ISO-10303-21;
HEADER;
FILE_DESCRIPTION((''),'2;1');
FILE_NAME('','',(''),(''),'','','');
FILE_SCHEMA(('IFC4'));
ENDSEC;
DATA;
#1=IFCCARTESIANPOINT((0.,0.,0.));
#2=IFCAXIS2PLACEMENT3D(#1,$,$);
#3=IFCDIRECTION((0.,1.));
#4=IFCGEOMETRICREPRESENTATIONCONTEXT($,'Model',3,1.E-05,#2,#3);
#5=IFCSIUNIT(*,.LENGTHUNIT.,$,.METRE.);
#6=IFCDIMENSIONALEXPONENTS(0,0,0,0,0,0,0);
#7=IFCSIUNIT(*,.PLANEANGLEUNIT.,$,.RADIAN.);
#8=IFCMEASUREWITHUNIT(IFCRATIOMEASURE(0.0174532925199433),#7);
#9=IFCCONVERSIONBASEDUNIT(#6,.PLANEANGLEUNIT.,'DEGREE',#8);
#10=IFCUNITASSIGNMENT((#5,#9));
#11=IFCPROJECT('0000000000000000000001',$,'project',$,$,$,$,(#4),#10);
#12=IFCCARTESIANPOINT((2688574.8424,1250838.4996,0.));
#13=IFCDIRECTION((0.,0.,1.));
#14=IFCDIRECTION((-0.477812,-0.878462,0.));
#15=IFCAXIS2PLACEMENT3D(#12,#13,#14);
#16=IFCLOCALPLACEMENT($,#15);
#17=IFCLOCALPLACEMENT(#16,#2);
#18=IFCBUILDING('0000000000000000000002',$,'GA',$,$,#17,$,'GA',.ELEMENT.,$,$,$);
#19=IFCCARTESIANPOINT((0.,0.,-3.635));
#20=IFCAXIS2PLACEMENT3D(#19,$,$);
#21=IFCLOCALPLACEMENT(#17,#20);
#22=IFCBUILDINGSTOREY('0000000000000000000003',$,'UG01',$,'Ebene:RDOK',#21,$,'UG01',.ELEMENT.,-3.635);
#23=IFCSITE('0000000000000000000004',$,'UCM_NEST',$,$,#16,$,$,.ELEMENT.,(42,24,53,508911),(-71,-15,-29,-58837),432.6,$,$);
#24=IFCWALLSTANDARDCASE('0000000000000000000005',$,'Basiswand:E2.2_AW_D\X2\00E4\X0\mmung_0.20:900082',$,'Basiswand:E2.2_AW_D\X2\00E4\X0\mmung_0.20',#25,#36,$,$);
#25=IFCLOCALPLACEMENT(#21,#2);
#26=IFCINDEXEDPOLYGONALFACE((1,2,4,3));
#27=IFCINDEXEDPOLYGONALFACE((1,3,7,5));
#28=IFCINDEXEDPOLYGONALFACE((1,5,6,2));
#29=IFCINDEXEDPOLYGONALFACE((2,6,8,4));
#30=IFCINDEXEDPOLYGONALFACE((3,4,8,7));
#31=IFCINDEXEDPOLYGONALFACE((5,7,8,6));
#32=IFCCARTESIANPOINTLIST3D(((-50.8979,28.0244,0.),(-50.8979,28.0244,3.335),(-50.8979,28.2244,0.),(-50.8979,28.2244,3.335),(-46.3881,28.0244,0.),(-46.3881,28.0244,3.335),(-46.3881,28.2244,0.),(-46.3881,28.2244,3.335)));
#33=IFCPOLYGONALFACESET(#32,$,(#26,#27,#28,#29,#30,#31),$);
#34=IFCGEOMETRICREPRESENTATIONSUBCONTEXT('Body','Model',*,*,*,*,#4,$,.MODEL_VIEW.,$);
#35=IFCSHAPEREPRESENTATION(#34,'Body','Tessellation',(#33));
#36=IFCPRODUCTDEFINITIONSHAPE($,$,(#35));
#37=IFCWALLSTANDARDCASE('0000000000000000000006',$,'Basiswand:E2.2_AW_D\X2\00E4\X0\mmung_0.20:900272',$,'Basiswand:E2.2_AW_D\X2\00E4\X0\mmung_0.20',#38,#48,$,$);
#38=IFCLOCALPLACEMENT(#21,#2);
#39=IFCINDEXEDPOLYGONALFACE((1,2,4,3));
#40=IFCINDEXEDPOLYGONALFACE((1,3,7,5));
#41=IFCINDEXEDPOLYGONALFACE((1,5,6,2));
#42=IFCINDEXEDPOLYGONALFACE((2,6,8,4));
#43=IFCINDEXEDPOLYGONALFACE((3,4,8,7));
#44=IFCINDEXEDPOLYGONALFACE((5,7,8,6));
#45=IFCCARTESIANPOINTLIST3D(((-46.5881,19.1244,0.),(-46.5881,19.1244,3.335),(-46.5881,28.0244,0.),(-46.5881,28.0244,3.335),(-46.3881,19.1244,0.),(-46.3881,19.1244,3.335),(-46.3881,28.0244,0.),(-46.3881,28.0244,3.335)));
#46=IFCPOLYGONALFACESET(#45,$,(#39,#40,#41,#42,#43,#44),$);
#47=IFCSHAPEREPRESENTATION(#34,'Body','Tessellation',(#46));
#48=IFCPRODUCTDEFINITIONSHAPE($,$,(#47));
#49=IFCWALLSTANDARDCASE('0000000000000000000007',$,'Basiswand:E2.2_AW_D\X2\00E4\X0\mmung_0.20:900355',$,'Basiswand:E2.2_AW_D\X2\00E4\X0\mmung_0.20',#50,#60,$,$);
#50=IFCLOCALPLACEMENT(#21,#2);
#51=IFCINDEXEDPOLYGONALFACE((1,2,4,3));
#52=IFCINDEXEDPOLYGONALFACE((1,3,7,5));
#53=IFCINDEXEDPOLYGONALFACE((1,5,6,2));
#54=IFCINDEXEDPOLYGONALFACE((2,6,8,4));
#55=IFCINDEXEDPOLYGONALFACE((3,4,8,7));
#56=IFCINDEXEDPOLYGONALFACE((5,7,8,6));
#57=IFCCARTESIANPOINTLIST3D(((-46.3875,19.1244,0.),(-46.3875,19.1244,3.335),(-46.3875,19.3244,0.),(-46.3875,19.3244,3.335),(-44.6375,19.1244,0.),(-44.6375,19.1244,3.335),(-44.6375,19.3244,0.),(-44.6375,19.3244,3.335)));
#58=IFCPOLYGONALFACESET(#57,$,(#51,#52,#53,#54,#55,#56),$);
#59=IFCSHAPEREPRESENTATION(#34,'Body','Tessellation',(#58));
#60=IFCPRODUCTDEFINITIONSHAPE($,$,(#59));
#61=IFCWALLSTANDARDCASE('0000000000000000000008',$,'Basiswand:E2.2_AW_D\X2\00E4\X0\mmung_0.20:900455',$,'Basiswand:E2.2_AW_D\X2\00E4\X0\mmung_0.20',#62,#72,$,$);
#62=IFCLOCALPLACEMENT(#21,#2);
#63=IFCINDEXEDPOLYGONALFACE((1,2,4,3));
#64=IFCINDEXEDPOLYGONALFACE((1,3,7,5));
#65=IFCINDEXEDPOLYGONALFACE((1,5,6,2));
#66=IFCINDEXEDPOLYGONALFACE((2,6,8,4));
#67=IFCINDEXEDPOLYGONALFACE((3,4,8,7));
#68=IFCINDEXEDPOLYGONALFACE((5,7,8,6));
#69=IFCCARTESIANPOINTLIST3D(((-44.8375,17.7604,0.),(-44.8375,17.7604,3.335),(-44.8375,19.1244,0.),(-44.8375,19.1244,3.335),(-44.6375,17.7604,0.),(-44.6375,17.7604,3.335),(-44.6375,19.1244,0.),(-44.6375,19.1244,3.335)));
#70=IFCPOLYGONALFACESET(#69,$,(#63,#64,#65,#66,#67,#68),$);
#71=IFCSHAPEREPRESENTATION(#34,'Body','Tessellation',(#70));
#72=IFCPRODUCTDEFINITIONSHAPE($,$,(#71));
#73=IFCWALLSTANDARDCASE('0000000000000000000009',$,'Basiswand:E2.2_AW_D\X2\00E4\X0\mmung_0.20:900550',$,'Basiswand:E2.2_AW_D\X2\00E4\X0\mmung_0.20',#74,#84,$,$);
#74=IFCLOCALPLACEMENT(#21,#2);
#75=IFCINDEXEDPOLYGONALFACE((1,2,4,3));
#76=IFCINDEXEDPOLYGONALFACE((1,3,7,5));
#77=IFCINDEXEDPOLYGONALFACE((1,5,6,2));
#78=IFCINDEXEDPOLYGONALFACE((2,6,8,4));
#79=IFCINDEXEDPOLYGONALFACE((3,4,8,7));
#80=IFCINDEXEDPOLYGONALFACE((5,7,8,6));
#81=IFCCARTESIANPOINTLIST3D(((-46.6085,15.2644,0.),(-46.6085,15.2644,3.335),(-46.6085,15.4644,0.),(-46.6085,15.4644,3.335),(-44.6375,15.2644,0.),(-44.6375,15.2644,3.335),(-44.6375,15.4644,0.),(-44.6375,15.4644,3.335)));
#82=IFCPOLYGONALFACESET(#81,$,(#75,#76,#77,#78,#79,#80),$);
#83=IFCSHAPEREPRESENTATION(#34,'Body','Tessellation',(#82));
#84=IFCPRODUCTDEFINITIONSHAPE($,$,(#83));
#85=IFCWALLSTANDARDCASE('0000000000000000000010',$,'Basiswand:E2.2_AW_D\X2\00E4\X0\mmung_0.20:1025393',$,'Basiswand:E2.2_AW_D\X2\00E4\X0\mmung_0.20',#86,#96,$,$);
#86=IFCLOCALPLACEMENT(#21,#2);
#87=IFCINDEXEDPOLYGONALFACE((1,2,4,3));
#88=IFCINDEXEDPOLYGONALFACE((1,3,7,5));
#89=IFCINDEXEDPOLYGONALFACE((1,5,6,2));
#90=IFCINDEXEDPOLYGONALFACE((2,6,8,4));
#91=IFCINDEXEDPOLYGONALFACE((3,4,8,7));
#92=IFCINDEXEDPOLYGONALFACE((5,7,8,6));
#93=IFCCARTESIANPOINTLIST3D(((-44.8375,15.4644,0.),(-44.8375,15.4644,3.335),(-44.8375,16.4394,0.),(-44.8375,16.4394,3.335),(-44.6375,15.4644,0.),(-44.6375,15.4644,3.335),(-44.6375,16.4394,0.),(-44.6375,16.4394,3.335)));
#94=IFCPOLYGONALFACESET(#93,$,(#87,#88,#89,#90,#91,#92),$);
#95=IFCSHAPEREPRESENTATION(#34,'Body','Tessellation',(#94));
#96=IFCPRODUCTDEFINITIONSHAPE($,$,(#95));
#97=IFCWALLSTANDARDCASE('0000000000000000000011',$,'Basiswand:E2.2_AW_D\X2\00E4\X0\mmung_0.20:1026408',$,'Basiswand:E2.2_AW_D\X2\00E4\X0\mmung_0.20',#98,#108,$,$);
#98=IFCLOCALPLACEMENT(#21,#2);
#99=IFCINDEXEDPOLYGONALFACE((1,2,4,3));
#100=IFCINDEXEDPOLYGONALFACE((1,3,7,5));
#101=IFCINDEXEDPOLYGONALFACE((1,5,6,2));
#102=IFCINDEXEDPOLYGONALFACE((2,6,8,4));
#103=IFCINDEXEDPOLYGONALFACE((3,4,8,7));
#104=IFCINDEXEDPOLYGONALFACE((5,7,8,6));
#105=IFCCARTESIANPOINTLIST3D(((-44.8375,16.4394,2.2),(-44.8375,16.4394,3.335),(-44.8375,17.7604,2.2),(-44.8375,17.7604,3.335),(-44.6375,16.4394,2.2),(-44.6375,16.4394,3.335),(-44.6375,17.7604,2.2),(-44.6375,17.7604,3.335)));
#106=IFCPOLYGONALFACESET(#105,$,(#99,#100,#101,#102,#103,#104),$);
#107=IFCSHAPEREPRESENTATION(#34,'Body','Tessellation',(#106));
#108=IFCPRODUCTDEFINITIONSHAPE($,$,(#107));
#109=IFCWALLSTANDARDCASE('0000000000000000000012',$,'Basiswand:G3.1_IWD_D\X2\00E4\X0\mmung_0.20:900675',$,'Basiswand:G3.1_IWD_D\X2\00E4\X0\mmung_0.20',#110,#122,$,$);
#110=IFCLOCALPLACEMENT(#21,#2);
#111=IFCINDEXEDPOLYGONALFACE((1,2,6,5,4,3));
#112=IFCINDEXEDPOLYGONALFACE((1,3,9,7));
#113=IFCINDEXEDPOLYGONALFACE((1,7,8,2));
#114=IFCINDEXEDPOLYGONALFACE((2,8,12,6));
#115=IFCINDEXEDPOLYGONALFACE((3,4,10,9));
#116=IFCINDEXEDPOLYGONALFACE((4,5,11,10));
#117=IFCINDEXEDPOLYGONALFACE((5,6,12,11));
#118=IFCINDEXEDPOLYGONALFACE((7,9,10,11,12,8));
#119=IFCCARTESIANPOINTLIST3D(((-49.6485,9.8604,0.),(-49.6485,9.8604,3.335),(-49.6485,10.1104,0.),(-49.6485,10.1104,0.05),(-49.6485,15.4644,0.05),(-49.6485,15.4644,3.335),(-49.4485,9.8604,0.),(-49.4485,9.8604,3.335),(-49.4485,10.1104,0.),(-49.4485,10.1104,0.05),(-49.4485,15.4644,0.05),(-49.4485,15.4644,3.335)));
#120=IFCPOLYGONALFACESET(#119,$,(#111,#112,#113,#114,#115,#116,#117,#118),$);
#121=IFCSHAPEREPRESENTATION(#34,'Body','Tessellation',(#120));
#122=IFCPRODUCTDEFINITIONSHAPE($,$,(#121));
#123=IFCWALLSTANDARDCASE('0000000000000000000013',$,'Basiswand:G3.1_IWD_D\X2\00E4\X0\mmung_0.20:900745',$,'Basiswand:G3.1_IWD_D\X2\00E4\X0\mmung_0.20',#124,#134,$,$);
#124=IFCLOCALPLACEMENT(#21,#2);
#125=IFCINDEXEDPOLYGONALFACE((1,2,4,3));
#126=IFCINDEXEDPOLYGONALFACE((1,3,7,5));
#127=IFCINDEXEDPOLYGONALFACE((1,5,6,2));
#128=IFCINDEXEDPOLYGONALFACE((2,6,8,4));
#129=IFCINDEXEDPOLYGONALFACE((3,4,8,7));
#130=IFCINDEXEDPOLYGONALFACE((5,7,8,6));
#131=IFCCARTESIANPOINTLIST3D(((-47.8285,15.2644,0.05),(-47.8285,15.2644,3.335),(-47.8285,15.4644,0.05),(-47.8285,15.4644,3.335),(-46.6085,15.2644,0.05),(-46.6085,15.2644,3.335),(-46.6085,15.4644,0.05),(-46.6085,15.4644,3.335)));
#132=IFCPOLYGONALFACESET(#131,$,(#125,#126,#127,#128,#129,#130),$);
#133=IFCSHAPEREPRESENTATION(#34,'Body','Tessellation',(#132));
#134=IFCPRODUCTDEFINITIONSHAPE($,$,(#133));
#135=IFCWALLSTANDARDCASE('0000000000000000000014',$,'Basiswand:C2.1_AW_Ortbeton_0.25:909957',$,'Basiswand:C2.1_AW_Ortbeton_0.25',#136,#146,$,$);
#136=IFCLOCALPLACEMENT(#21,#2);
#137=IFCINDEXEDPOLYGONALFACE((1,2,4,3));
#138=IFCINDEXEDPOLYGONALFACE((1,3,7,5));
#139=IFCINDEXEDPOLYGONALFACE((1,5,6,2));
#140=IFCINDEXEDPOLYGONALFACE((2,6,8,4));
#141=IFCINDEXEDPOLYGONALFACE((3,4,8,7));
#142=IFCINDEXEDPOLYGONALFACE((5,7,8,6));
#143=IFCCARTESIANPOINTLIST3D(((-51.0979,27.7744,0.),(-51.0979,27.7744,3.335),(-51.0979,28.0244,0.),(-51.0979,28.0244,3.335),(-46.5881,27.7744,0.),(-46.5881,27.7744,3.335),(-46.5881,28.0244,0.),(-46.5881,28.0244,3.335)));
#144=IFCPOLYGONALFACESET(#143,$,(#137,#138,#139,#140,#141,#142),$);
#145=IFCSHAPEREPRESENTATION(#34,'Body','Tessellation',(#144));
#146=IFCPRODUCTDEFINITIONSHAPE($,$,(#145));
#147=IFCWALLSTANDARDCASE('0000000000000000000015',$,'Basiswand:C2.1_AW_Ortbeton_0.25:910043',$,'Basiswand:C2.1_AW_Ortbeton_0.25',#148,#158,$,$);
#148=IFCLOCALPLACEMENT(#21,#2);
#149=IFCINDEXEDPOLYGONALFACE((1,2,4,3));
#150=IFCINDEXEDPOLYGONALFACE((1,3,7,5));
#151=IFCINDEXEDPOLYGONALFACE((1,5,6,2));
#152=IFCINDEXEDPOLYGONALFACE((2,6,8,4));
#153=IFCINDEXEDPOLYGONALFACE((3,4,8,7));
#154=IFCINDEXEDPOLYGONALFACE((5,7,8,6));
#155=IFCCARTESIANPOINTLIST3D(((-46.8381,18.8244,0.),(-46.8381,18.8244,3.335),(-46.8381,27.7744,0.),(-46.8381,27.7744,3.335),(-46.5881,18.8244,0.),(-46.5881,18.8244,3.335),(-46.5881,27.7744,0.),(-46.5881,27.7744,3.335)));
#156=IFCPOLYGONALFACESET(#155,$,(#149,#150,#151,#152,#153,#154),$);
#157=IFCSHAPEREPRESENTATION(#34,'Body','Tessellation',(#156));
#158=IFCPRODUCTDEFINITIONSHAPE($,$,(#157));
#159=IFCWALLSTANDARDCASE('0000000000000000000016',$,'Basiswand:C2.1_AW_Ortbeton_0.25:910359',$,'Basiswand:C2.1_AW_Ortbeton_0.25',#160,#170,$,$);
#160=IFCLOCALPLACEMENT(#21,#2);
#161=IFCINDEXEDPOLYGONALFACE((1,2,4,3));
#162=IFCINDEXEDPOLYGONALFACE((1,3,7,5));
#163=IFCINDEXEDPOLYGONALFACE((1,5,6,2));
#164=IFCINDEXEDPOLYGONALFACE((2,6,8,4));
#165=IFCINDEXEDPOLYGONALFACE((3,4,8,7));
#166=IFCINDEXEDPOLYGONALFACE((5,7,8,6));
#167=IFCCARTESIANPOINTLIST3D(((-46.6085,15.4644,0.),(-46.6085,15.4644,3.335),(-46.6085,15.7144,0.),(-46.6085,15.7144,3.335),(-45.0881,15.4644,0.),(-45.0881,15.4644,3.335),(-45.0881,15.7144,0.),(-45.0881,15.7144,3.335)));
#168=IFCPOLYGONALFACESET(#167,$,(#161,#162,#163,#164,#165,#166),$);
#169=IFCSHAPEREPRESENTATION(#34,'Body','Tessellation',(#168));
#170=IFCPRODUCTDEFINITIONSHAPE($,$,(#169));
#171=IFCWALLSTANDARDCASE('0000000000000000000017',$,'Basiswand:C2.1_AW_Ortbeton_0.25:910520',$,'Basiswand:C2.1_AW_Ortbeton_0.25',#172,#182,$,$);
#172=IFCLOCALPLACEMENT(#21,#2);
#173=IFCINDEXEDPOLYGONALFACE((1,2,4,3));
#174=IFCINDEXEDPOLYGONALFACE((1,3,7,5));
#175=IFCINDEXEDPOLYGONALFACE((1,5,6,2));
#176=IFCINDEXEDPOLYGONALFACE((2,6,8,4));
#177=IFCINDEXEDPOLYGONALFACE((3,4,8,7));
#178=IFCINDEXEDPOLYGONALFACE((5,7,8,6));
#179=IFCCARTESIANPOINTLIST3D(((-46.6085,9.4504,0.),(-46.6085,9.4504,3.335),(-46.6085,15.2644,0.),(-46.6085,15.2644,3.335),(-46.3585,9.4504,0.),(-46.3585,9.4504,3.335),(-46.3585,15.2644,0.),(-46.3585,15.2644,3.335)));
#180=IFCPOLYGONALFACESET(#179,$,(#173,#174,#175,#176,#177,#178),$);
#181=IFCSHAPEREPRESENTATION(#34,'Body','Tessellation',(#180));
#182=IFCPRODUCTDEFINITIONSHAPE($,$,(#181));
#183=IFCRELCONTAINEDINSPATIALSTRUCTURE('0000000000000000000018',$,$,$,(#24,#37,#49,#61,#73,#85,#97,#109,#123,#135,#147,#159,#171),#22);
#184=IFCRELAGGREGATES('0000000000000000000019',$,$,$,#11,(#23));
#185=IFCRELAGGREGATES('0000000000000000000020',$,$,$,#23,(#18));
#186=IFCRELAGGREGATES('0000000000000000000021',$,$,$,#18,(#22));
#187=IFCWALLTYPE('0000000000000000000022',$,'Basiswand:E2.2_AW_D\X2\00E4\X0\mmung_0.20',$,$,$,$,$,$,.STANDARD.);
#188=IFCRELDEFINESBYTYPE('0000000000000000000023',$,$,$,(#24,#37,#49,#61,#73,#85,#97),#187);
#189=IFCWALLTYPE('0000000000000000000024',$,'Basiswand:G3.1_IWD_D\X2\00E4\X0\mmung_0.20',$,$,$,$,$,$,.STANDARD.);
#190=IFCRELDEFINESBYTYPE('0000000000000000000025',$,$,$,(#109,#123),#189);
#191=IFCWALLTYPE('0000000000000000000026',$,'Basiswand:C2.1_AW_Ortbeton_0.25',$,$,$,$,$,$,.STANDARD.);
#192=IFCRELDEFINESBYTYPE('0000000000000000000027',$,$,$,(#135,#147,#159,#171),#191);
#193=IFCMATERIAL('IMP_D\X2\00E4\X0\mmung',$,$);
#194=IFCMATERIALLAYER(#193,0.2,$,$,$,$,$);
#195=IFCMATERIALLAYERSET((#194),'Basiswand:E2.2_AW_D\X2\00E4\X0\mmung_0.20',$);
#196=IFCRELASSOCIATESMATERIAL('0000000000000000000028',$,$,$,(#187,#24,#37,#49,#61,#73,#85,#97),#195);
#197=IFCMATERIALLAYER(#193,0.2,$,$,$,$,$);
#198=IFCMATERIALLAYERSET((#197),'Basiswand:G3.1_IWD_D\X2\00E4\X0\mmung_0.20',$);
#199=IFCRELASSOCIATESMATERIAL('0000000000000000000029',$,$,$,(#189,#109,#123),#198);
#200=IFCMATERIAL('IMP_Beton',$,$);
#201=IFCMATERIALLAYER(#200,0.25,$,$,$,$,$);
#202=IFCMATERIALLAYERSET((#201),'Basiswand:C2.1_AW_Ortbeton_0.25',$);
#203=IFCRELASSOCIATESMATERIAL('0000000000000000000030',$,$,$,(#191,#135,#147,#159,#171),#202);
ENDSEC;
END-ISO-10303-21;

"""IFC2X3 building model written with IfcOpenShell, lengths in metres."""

from ifc_helpers import new_model, entity, si_unit, converted_unit, direction, frame, frame_2d, origin, place, context, subcontext, project, spatial, polyline, rectangle, extrude, clip, bounded_halfspace, material, layer, layer_set, layer_usage, type_object, element, save


model = new_model("IFC2X3")

# Units and contexts
model_context = context("Model", 3, precision=1e-05, world=origin(), true_north=direction((0.0, 1.0)))
body_context = subcontext(model_context, "Body", "Model", "MODEL_VIEW")
ifc_project = project(units=[si_unit("LENGTHUNIT", "METRE"), converted_unit("PLANEANGLEUNIT", "DEGREE", entity("IfcRatioMeasure", 0.0174532925199433), si_unit("PLANEANGLEUNIT", "RADIAN"), dimensions=[0, 0, 0, 0, 0, 0, 0])], contexts=[model_context])

# Site, building, storey
site_placement = place(None, frame((2688574.8424, 1250838.4996, 0.0), z_axis=(0.0, 0.0, 1.0), x_axis=(-0.477812, -0.878462, 0.0)))
site = spatial("IfcSite", under=ifc_project, at=site_placement, Name="UCM_NEST", CompositionType="ELEMENT", RefLatitude=(42, 24, 53, 508911), RefLongitude=(-71, -15, -29, -58837), RefElevation=432.6)
building_placement = place(site_placement, origin())
building = spatial("IfcBuilding", under=site, at=building_placement, Name="GA", LongName="GA", CompositionType="ELEMENT")
storey_placement = place(building_placement, frame((0.0, 0.0, -3.635)))
storey = spatial("IfcBuildingStorey", under=building, at=storey_placement, Name="UG01", ObjectType="Ebene:RDOK", LongName="UG01", CompositionType="ELEMENT", Elevation=-3.635)

# Shared definitions
ifc_material_1 = material(Name="IMP_Beton")

# Walls
ifc_material_2 = material(Name="IMP_Dämmung")
ifc_layer_1 = layer(ifc_material_2, 0.2)
ifc_layer_set_1 = layer_set([ifc_layer_1], Name="Basiswand:E2.2_AW_Dämmung_0.20")
ifc_layer_usage_1 = layer_usage(ifc_layer_set_1, "AXIS2", "NEGATIVE", 0.1)
wall_type_1 = type_object("IfcWallType", Name="Basiswand:E2.2_AW_Dämmung_0.20", PredefinedType="STANDARD", material=ifc_layer_set_1)
wall_1_placement = place(storey_placement, frame((-50.8979, 28.1244, 0.0)))
element("IfcWallStandardCase", 1, at=wall_1_placement, inside=storey, type_object=wall_type_1, material=ifc_layer_usage_1, Name="Basiswand:E2.2_AW_Dämmung_0.20:900082", ObjectType="Basiswand:E2.2_AW_Dämmung_0.20", context=body_context, shape_type="SweptSolid", body=[
    extrude(rectangle(XDim=4.5099, YDim=0.2, at=frame_2d((2.2549, 0.0), x_axis=(-1.0, 0.0))), origin(), (0.0, 0.0, 1.0), 3.335),
])
ifc_layer_usage_2 = layer_usage(ifc_layer_set_1, "AXIS2", "NEGATIVE", 0.1)
wall_2_placement = place(storey_placement, frame((-46.4881, 28.0244, 0.0), z_axis=(0.0, 0.0, 1.0), x_axis=(0.0, -1.0, 0.0)))
element("IfcWallStandardCase", 2, at=wall_2_placement, inside=storey, type_object=wall_type_1, material=ifc_layer_usage_2, Name="Basiswand:E2.2_AW_Dämmung_0.20:900272", ObjectType="Basiswand:E2.2_AW_Dämmung_0.20", context=body_context, shape_type="SweptSolid", body=[
    extrude(rectangle(XDim=8.9, YDim=0.2, at=frame_2d((4.45, 0.0), x_axis=(-1.0, 0.0))), origin(), (0.0, 0.0, 1.0), 3.335),
])
ifc_layer_usage_3 = layer_usage(ifc_layer_set_1, "AXIS2", "NEGATIVE", 0.1)
wall_3_placement = place(storey_placement, frame((-46.3875, 19.2244, 0.0)))
element("IfcWallStandardCase", 3, at=wall_3_placement, inside=storey, type_object=wall_type_1, material=ifc_layer_usage_3, Name="Basiswand:E2.2_AW_Dämmung_0.20:900355", ObjectType="Basiswand:E2.2_AW_Dämmung_0.20", context=body_context, shape_type="SweptSolid", body=[
    extrude(rectangle(XDim=1.75, YDim=0.2, at=frame_2d((0.875, 0.0), x_axis=(-1.0, 0.0))), origin(), (0.0, 0.0, 1.0), 3.335),
])
ifc_layer_usage_4 = layer_usage(ifc_layer_set_1, "AXIS2", "NEGATIVE", 0.1)
wall_4_placement = place(storey_placement, frame((-44.7375, 19.1244, 0.0), z_axis=(0.0, 0.0, 1.0), x_axis=(0.0, -1.0, 0.0)))
element("IfcWallStandardCase", 4, at=wall_4_placement, inside=storey, type_object=wall_type_1, material=ifc_layer_usage_4, Name="Basiswand:E2.2_AW_Dämmung_0.20:900455", ObjectType="Basiswand:E2.2_AW_Dämmung_0.20", context=body_context, shape_type="SweptSolid", body=[
    extrude(rectangle(XDim=1.364, YDim=0.2, at=frame_2d((0.682, 0.0), x_axis=(-1.0, 0.0))), origin(), (0.0, 0.0, 1.0), 3.335),
])
ifc_layer_usage_5 = layer_usage(ifc_layer_set_1, "AXIS2", "NEGATIVE", 0.1)
wall_5_placement = place(storey_placement, frame((-44.6375, 15.3644, 0.0), z_axis=(0.0, 0.0, 1.0), x_axis=(-1.0, 0.0, 0.0)))
element("IfcWallStandardCase", 5, at=wall_5_placement, inside=storey, type_object=wall_type_1, material=ifc_layer_usage_5, Name="Basiswand:E2.2_AW_Dämmung_0.20:900550", ObjectType="Basiswand:E2.2_AW_Dämmung_0.20", context=body_context, shape_type="SweptSolid", body=[
    extrude(rectangle(XDim=1.971, YDim=0.2, at=frame_2d((0.9855, 0.0), x_axis=(-1.0, 0.0))), origin(), (0.0, 0.0, 1.0), 3.335),
])
ifc_layer_usage_6 = layer_usage(ifc_layer_set_1, "AXIS2", "NEGATIVE", 0.1)
wall_6_placement = place(storey_placement, frame((-44.7375, 16.4394, 0.0), z_axis=(0.0, 0.0, 1.0), x_axis=(0.0, -1.0, 0.0)))
element("IfcWallStandardCase", 6, at=wall_6_placement, inside=storey, type_object=wall_type_1, material=ifc_layer_usage_6, Name="Basiswand:E2.2_AW_Dämmung_0.20:1025393", ObjectType="Basiswand:E2.2_AW_Dämmung_0.20", context=body_context, shape_type="SweptSolid", body=[
    extrude(rectangle(XDim=0.975, YDim=0.2, at=frame_2d((0.4875, 0.0), x_axis=(-1.0, 0.0))), origin(), (0.0, 0.0, 1.0), 3.335),
])
ifc_layer_usage_7 = layer_usage(ifc_layer_set_1, "AXIS2", "NEGATIVE", 0.1)
wall_7_placement = place(storey_placement, frame((-44.7375, 17.7604, 2.2), z_axis=(0.0, 0.0, 1.0), x_axis=(0.0, -1.0, 0.0)))
element("IfcWallStandardCase", 7, at=wall_7_placement, inside=storey, type_object=wall_type_1, material=ifc_layer_usage_7, Name="Basiswand:E2.2_AW_Dämmung_0.20:1026408", ObjectType="Basiswand:E2.2_AW_Dämmung_0.20", context=body_context, shape_type="SweptSolid", body=[
    extrude(rectangle(XDim=1.321, YDim=0.2, at=frame_2d((0.6605, 0.0), x_axis=(-1.0, 0.0))), origin(), (0.0, 0.0, 1.0), 1.135),
])
ifc_layer_2 = layer(ifc_material_2, 0.2)
ifc_layer_set_2 = layer_set([ifc_layer_2], Name="Basiswand:G3.1_IWD_Dämmung_0.20")
ifc_layer_usage_8 = layer_usage(ifc_layer_set_2, "AXIS2", "NEGATIVE", 0.1)
wall_type_2 = type_object("IfcWallType", Name="Basiswand:G3.1_IWD_Dämmung_0.20", PredefinedType="STANDARD", material=ifc_layer_set_2)
wall_8_placement = place(storey_placement, frame((-49.5485, 15.4644, 0.0), z_axis=(0.0, 0.0, 1.0), x_axis=(0.0, -1.0, 0.0)))
element("IfcWallStandardCase", 8, at=wall_8_placement, inside=storey, type_object=wall_type_2, material=ifc_layer_usage_8, Name="Basiswand:G3.1_IWD_Dämmung_0.20:900675", ObjectType="Basiswand:G3.1_IWD_Dämmung_0.20", context=body_context, shape_type="Clipping", body=[
    clip(clip(extrude(rectangle(XDim=5.604, YDim=0.2, at=frame_2d((2.802, 0.0), x_axis=(-1.0, 0.0))), origin(), (0.0, 0.0, 1.0), 3.335), bounded_halfspace(frame((5.354, 0.1, 0.05), z_axis=(0.0, 0.0, 1.0), x_axis=(-1.0, 0.0, 0.0)), True, frame((5.354, 0.1, 0.05), z_axis=(0.0, 0.0, 1.0), x_axis=(-1.0, 0.0, 0.0)), polyline([(0.0, 0.0), (5.354, 0.0), (5.354, 0.2), (0.0, 0.2), (0.0, 0.0)]))), bounded_halfspace(frame((5.354, -0.1, 0.05), z_axis=(1.0, 0.0, 0.0), x_axis=(0.0, 0.0, 1.0)), True, frame((5.354, -0.1, 0.05), z_axis=(1.0, 0.0, 0.0), x_axis=(0.0, 0.0, 1.0)), polyline([(0.0, 0.0), (-0.05, 0.0), (-0.05, -0.2), (0.0, -0.2), (0.0, 0.0)]))),
])
ifc_layer_usage_9 = layer_usage(ifc_layer_set_2, "AXIS2", "NEGATIVE", 0.1)
wall_9_placement = place(storey_placement, frame((-47.8285, 15.3644, 0.05)))
element("IfcWallStandardCase", 9, at=wall_9_placement, inside=storey, type_object=wall_type_2, material=ifc_layer_usage_9, Name="Basiswand:G3.1_IWD_Dämmung_0.20:900745", ObjectType="Basiswand:G3.1_IWD_Dämmung_0.20", context=body_context, shape_type="Clipping", body=[
    clip(extrude(rectangle(XDim=1.22, YDim=0.2, at=frame_2d((0.61, 0.0), x_axis=(-1.0, 0.0))), origin(), (0.0, 0.0, 1.0), 3.285), bounded_halfspace(frame((1.22, -0.1, 0.0), z_axis=(0.0, 0.0, 1.0), x_axis=(0.0, 1.0, 0.0)), True, frame((1.22, -0.1, 0.0), z_axis=(0.0, 0.0, 1.0), x_axis=(0.0, 1.0, 0.0)), polyline([(0.0, 0.0), (0.2, 0.0), (0.2, 1.22), (0.0, 1.22), (0.0, 0.0)]))),
])
ifc_layer_3 = layer(ifc_material_1, 0.25)
ifc_layer_set_3 = layer_set([ifc_layer_3], Name="Basiswand:C2.1_AW_Ortbeton_0.25")
ifc_layer_usage_10 = layer_usage(ifc_layer_set_3, "AXIS2", "NEGATIVE", 0.125)
wall_type_3 = type_object("IfcWallType", Name="Basiswand:C2.1_AW_Ortbeton_0.25", PredefinedType="STANDARD", material=ifc_layer_set_3)
wall_10_placement = place(storey_placement, frame((-51.0979, 27.8994, 0.0)))
element("IfcWallStandardCase", 10, at=wall_10_placement, inside=storey, type_object=wall_type_3, material=ifc_layer_usage_10, Name="Basiswand:C2.1_AW_Ortbeton_0.25:909957", ObjectType="Basiswand:C2.1_AW_Ortbeton_0.25", context=body_context, shape_type="SweptSolid", body=[
    extrude(rectangle(XDim=4.5099, YDim=0.25, at=frame_2d((2.2549, 0.0), x_axis=(-1.0, 0.0))), origin(), (0.0, 0.0, 1.0), 3.335),
])
ifc_layer_usage_11 = layer_usage(ifc_layer_set_3, "AXIS2", "NEGATIVE", 0.125)
wall_11_placement = place(storey_placement, frame((-46.7131, 27.7744, 0.0), z_axis=(0.0, 0.0, 1.0), x_axis=(0.0, -1.0, 0.0)))
element("IfcWallStandardCase", 11, at=wall_11_placement, inside=storey, type_object=wall_type_3, material=ifc_layer_usage_11, Name="Basiswand:C2.1_AW_Ortbeton_0.25:910043", ObjectType="Basiswand:C2.1_AW_Ortbeton_0.25", context=body_context, shape_type="SweptSolid", body=[
    extrude(rectangle(XDim=8.95, YDim=0.25, at=frame_2d((4.475, 0.0), x_axis=(-1.0, 0.0))), origin(), (0.0, 0.0, 1.0), 3.335),
])

# Walls
ifc_layer_usage_12 = layer_usage(ifc_layer_set_3, "AXIS2", "NEGATIVE", 0.125)
wall_12_placement = place(storey_placement, frame((-45.0881, 15.5894, 0.0), z_axis=(0.0, 0.0, 1.0), x_axis=(-1.0, 0.0, 0.0)))
element("IfcWallStandardCase", 12, at=wall_12_placement, inside=storey, type_object=wall_type_3, material=ifc_layer_usage_12, Name="Basiswand:C2.1_AW_Ortbeton_0.25:910359", ObjectType="Basiswand:C2.1_AW_Ortbeton_0.25", context=body_context, shape_type="SweptSolid", body=[
    extrude(rectangle(XDim=1.5204, YDim=0.25, at=frame_2d((0.7602, 0.0), x_axis=(-1.0, 0.0))), origin(), (0.0, 0.0, 1.0), 3.335),
])
ifc_layer_usage_13 = layer_usage(ifc_layer_set_3, "AXIS2", "NEGATIVE", 0.125)
wall_13_placement = place(storey_placement, frame((-46.4835, 15.2644, 0.0), z_axis=(0.0, 0.0, 1.0), x_axis=(0.0, -1.0, 0.0)))
element("IfcWallStandardCase", 13, at=wall_13_placement, inside=storey, type_object=wall_type_3, material=ifc_layer_usage_13, Name="Basiswand:C2.1_AW_Ortbeton_0.25:910520", ObjectType="Basiswand:C2.1_AW_Ortbeton_0.25", context=body_context, shape_type="SweptSolid", body=[
    extrude(rectangle(XDim=5.814, YDim=0.25, at=frame_2d((2.907, 0.0), x_axis=(-1.0, 0.0))), origin(), (0.0, 0.0, 1.0), 3.335),
])

save(model, "model.ifc")
